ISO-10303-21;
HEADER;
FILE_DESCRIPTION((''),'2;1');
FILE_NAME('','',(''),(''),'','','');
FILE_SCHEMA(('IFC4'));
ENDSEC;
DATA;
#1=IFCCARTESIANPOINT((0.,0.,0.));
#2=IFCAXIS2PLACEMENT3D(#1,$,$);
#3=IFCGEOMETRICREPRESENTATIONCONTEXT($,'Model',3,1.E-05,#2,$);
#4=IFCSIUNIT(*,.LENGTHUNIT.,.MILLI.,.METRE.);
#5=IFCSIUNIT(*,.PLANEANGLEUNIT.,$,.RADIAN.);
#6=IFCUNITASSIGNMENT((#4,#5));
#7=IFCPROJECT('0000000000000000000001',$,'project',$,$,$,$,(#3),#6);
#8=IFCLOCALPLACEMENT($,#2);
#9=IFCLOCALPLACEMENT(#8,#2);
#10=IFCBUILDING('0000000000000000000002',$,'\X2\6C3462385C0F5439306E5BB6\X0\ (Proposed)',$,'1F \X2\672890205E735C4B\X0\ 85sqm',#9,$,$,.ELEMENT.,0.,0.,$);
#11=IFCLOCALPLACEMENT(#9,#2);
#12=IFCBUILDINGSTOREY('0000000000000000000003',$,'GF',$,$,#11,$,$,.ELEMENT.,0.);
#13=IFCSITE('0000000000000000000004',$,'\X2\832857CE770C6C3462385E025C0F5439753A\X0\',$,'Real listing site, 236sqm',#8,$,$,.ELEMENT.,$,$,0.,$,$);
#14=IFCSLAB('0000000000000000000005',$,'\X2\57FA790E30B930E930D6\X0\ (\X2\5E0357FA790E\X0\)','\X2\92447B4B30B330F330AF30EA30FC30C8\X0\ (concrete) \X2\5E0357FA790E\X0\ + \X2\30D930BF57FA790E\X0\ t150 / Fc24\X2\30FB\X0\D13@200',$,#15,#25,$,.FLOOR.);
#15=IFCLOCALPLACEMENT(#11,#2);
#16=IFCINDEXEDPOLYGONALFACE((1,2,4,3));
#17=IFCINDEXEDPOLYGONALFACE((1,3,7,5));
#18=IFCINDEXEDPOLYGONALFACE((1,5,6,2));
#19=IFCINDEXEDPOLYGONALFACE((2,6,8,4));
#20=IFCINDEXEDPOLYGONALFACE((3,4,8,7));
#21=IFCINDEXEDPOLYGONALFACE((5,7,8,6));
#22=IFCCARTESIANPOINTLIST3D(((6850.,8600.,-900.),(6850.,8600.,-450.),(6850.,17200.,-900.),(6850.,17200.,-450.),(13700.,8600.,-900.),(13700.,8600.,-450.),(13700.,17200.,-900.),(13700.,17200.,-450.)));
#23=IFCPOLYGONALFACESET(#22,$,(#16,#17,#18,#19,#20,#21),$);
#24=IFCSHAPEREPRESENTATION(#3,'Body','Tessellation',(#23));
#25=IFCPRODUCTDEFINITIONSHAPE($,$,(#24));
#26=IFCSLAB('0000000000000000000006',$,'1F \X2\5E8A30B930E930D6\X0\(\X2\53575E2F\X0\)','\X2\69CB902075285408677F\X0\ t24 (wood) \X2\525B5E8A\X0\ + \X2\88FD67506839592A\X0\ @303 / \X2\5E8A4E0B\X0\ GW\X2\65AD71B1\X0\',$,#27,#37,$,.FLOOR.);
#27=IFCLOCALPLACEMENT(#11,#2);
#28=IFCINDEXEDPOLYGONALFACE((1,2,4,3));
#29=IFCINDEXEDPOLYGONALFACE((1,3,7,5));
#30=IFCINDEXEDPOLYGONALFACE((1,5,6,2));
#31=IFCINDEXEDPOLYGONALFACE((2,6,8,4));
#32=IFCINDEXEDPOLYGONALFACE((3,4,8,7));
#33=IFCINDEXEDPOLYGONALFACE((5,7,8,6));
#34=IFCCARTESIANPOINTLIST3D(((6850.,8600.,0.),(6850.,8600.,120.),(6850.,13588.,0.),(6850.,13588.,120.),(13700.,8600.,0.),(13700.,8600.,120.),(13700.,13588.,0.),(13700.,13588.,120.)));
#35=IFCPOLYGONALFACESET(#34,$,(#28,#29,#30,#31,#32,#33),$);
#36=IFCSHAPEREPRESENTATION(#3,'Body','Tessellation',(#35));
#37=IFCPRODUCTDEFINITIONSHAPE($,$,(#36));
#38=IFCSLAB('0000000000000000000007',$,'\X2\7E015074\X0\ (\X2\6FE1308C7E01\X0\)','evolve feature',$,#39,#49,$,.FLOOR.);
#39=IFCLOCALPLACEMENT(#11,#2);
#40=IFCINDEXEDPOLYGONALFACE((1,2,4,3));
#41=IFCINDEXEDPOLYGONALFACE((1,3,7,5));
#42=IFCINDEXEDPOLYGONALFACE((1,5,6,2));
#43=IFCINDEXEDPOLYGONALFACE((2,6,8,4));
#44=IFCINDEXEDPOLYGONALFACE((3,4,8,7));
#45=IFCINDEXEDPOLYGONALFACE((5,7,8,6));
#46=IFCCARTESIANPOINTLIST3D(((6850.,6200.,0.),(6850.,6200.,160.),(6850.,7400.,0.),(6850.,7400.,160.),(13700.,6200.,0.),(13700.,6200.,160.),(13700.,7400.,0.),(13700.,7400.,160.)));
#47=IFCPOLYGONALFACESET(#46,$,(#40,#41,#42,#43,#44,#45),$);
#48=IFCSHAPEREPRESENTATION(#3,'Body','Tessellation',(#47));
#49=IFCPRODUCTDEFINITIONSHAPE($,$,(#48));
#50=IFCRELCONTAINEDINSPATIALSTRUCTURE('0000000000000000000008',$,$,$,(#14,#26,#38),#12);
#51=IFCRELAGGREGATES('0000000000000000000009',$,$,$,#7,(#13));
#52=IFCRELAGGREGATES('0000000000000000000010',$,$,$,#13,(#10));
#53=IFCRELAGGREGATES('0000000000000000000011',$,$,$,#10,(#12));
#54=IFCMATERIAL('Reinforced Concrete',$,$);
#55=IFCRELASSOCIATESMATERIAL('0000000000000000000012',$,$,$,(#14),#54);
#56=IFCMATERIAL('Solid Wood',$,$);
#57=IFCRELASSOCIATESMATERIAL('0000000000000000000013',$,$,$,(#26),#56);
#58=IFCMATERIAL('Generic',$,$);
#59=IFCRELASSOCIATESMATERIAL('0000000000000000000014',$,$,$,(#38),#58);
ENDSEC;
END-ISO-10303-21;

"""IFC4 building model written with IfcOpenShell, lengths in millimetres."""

from ifc_helpers import new_model, si_unit, frame, frame_2d, origin, place, context, project, spatial, rectangle, extrude, material, element, save


model = new_model("IFC4")

# Units and contexts
model_context = context("Model", 3, precision=1e-05, world=origin())
ifc_project = project(units=[si_unit("LENGTHUNIT", "METRE", prefix="MILLI"), si_unit("PLANEANGLEUNIT", "RADIAN")], contexts=[model_context])

# Site, building, storey
site_placement = place(None, origin())
site = spatial("IfcSite", under=ifc_project, at=site_placement, Name="茨城県水戸市小吹町", ObjectType="Real listing site, 236sqm", CompositionType="ELEMENT", RefElevation=0.0)
building_placement = place(site_placement, origin())
building = spatial("IfcBuilding", under=site, at=building_placement, Name="水戸小吹の家 (Proposed)", ObjectType="1F 木造平屋 85sqm", CompositionType="ELEMENT", ElevationOfRefHeight=0.0, ElevationOfTerrain=0.0)
storey_placement = place(building_placement, origin())
storey = spatial("IfcBuildingStorey", under=building, at=storey_placement, Name="GF", CompositionType="ELEMENT", Elevation=0.0)

# Slabs
ifc_material_1 = material(Name="Reinforced Concrete")
slab_1_placement = place(storey_placement, frame((3425.0, 4300.0, -450.0)))
element("IfcSlab", 1, at=slab_1_placement, inside=storey, material=ifc_material_1, Name="基礎スラブ (布基礎)", Description="鉄筋コンクリート (concrete) 布基礎 + ベタ基礎 t150 / Fc24・D13@200", PredefinedType="FLOOR", context=model_context, shape_type="SweptSolid", body=[
    extrude(rectangle(XDim=6850.0, YDim=8600.0, at=frame_2d((3425.0, 4300.0))), frame((3425.0, 4300.0, -450.0)), (0.0, 0.0, 1.0), 450.0),
])
ifc_material_2 = material(Name="Solid Wood")
slab_2_placement = place(storey_placement, frame((3425.0, 4300.0, 0.0)))
element("IfcSlab", 2, at=slab_2_placement, inside=storey, material=ifc_material_2, Name="1F 床スラブ(南帯)", Description="構造用合板 t24 (wood) 剛床 + 製材根太 @303 / 床下 GW断熱", PredefinedType="FLOOR", context=model_context, shape_type="SweptSolid", body=[
    extrude(rectangle(XDim=6850.0, YDim=4988.0, at=frame_2d((3425.0, 2494.0))), frame((3425.0, 4300.0, 0.0)), (0.0, 0.0, 1.0), 120.0),
])
ifc_material_3 = material(Name="Generic")
slab_3_placement = place(storey_placement, frame((3425.0, 3100.0, 0.0)))
element("IfcSlab", 3, at=slab_3_placement, inside=storey, material=ifc_material_3, Name="縁側 (濡れ縁)", Description="evolve feature", PredefinedType="FLOOR", context=model_context, shape_type="SweptSolid", body=[
    extrude(rectangle(XDim=6850.0, YDim=1200.0, at=frame_2d((3425.0, 600.0))), frame((3425.0, 3100.0, 0.0)), (0.0, 0.0, 1.0), 160.0),
])

save(model, "model.ifc")
